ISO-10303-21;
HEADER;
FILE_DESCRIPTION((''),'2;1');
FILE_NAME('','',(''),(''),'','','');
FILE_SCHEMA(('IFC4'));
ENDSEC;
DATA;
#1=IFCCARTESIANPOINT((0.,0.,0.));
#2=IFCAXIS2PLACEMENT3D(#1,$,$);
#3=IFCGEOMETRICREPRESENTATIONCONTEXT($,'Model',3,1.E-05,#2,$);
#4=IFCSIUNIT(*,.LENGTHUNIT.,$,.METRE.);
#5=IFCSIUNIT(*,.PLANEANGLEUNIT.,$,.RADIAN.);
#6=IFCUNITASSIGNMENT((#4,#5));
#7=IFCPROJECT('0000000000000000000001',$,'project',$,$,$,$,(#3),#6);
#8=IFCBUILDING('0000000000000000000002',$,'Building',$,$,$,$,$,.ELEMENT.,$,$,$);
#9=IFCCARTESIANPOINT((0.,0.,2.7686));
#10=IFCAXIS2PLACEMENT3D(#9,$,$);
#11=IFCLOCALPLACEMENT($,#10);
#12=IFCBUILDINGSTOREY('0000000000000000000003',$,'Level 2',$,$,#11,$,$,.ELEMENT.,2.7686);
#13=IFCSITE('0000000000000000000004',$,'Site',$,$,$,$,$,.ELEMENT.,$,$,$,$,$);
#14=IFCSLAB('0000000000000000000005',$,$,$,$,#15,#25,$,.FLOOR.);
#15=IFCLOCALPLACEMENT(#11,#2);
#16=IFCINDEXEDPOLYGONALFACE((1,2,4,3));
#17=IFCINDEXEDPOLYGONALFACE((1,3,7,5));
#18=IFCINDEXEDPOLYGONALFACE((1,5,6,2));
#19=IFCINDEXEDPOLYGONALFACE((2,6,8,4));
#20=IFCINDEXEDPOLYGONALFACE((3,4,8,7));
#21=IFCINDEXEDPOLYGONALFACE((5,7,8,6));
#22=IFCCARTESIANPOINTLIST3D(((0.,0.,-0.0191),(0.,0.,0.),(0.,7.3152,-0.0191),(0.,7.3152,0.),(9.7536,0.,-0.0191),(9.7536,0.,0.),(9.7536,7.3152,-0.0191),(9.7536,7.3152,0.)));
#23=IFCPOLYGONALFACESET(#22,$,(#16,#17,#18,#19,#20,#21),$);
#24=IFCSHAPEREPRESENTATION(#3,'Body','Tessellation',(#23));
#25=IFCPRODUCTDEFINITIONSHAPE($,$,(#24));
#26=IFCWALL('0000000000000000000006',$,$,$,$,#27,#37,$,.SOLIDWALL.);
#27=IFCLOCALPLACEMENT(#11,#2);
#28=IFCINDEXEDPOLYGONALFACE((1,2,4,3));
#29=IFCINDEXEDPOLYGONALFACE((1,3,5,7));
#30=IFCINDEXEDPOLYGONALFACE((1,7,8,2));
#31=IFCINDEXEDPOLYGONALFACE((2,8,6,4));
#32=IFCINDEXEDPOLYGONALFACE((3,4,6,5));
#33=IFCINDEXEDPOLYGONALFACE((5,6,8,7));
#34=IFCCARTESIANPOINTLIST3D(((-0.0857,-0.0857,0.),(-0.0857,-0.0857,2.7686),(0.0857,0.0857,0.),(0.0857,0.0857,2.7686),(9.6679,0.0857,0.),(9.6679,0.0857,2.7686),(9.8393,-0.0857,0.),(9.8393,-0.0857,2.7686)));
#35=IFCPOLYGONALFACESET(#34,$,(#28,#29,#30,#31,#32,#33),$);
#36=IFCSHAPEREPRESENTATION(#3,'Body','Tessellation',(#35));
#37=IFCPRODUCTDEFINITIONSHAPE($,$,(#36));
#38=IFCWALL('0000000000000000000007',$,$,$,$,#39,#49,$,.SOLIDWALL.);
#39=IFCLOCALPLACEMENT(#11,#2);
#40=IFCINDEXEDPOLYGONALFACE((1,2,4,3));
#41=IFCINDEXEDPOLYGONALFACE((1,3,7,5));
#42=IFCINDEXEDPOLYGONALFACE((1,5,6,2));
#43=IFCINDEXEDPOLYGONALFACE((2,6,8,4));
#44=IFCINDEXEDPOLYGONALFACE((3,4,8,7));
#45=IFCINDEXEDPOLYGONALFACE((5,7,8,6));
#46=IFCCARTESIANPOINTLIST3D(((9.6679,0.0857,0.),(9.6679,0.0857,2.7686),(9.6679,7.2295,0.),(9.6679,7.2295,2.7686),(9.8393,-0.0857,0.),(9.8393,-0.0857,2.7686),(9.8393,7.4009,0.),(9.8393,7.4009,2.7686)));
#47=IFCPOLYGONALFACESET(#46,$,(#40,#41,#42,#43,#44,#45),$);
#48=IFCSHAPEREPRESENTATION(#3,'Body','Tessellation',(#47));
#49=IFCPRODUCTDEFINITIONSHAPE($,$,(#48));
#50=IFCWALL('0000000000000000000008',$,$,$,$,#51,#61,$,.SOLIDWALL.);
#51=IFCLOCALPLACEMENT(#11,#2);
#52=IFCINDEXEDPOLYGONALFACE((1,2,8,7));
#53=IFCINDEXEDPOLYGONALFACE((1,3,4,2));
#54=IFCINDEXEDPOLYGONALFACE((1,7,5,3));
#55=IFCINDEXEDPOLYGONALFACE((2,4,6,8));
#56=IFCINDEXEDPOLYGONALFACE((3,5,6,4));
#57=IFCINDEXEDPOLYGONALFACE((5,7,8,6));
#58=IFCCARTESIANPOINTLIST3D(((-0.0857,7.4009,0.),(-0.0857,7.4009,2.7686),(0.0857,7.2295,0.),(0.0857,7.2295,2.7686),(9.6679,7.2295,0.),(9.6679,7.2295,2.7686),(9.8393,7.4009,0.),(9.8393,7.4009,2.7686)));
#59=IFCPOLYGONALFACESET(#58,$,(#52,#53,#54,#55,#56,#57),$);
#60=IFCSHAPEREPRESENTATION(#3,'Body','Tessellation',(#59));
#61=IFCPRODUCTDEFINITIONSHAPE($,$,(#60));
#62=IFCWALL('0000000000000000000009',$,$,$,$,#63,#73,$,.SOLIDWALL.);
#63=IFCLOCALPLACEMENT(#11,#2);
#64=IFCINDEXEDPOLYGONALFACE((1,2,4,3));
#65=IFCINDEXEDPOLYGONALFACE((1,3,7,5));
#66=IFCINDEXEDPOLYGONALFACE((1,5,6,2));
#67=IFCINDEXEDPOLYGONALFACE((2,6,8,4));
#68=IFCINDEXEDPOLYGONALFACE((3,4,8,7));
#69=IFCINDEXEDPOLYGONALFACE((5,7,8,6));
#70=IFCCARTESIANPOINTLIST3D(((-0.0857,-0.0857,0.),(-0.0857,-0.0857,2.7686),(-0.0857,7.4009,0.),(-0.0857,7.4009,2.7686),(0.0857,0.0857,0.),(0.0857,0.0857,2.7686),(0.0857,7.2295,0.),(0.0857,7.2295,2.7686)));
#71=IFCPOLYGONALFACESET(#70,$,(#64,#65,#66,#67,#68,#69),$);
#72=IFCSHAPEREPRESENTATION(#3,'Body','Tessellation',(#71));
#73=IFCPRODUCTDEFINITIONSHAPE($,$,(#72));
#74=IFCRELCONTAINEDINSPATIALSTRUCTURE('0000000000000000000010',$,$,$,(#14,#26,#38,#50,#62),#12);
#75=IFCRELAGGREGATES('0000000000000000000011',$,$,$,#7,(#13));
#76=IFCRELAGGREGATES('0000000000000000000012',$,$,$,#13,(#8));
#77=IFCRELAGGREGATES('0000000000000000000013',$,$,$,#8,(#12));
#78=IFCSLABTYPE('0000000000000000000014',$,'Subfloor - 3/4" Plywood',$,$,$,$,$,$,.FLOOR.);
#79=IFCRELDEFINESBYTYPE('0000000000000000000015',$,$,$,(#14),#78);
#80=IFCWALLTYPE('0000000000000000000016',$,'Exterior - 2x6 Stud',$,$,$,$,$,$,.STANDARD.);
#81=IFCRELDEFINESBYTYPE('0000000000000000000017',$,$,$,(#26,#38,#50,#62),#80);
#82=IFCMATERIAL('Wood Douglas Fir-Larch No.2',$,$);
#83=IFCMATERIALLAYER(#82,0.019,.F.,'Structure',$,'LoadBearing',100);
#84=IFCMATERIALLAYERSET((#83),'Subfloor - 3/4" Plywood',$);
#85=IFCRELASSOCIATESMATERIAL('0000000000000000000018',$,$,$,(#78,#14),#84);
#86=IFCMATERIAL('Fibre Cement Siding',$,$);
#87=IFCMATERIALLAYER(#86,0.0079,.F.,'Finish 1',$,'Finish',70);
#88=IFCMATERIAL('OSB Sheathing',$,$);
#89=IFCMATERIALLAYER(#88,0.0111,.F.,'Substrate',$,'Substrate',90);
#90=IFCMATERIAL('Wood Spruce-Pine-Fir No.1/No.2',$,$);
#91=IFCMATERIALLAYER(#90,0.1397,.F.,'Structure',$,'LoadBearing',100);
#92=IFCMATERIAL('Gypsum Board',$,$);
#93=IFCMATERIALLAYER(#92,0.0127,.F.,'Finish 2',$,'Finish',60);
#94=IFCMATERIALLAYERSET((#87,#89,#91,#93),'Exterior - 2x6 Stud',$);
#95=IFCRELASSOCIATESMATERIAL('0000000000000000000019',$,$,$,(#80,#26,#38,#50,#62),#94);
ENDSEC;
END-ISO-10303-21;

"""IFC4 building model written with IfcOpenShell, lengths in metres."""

from ifc_helpers import new_model, si_unit, frame, origin, place, context, project, spatial, polyline, outline, extrude, material, layer, layer_set, layer_usage, type_object, element, save


model = new_model("IFC4")

# Units and contexts
model_context = context("Model", 3, precision=1e-05, world=origin())
ifc_project = project(units=[si_unit("LENGTHUNIT", "METRE"), si_unit("PLANEANGLEUNIT", "RADIAN")], contexts=[model_context])

# Site, building, storey
site = spatial("IfcSite", under=ifc_project, Name="Site", CompositionType="ELEMENT")
building = spatial("IfcBuilding", under=site, Name="Building", CompositionType="ELEMENT")
storey_placement = place(None, frame((0.0, 0.0, 2.7686)))
storey = spatial("IfcBuildingStorey", under=building, at=storey_placement, Name="Level 2", CompositionType="ELEMENT", Elevation=2.7686)

# Slab
ifc_material_1 = material(Name="Wood Douglas Fir-Larch No.2")
ifc_layer_1 = layer(ifc_material_1, 0.019, ventilated=False, Name="Structure", Category="LoadBearing", Priority=100)
ifc_layer_set_1 = layer_set([ifc_layer_1], Name="Subfloor - 3/4\" Plywood")
ifc_layer_usage_1 = layer_usage(ifc_layer_set_1, "AXIS3", "NEGATIVE", 0.0)
slab_type = type_object("IfcSlabType", Name="Subfloor - 3/4\" Plywood", PredefinedType="FLOOR", material=ifc_layer_set_1)
slab_placement = place(None, frame((0.0, 0.0, 2.7686)))
element("IfcSlab", 1, at=slab_placement, inside=storey, type_object=slab_type, material=ifc_layer_usage_1, PredefinedType="FLOOR", context=model_context, shape_type="SweptSolid", body=[
    extrude(outline(polyline([(0.0, 0.0), (9.7536, 0.0), (9.7536, 7.3152), (0.0, 7.3152), (0.0, 0.0)])), origin(), (0.0, 0.0, -1.0), 0.019),
])

# Walls
ifc_material_2 = material(Name="Fibre Cement Siding")
ifc_layer_2 = layer(ifc_material_2, 0.0079, ventilated=False, Name="Finish 1", Category="Finish", Priority=70)
ifc_material_3 = material(Name="OSB Sheathing")
ifc_layer_3 = layer(ifc_material_3, 0.0111, ventilated=False, Name="Substrate", Category="Substrate", Priority=90)
ifc_material_4 = material(Name="Wood Spruce-Pine-Fir No.1/No.2")
ifc_layer_4 = layer(ifc_material_4, 0.1397, ventilated=False, Name="Structure", Category="LoadBearing", Priority=100)
ifc_material_5 = material(Name="Gypsum Board")
ifc_layer_5 = layer(ifc_material_5, 0.0127, ventilated=False, Name="Finish 2", Category="Finish", Priority=60)
ifc_layer_set_2 = layer_set([ifc_layer_2, ifc_layer_3, ifc_layer_4, ifc_layer_5], Name="Exterior - 2x6 Stud")
ifc_layer_usage_2 = layer_usage(ifc_layer_set_2, "AXIS2", "POSITIVE", -0.0857)
wall_type = type_object("IfcWallType", Name="Exterior - 2x6 Stud", PredefinedType="STANDARD", material=ifc_layer_set_2)
wall_1_placement = place(None, frame((9.7536, 0.0, 2.7686), z_axis=(0.0, 0.0, 1.0), x_axis=(-1.0, 0.0, 0.0)))
element("IfcWall", 2, at=wall_1_placement, inside=storey, type_object=wall_type, material=ifc_layer_usage_2, PredefinedType="SOLIDWALL", context=model_context, shape_type="SweptSolid", body=[
    extrude(outline(polyline([(0.0857, -0.0857), (9.6679, -0.0857), (9.8393, 0.0857), (-0.0857, 0.0857), (0.0857, -0.0857)])), origin(), (0.0, 0.0, 1.0), 2.7686),
])
wall_2_placement = place(None, frame((9.7536, 7.3152, 2.7686), z_axis=(0.0, 0.0, 1.0), x_axis=(0.0, -1.0, 0.0)))
element("IfcWall", 3, at=wall_2_placement, inside=storey, type_object=wall_type, material=ifc_layer_usage_2, PredefinedType="SOLIDWALL", context=model_context, shape_type="SweptSolid", body=[
    extrude(outline(polyline([(0.0857, -0.0857), (7.2295, -0.0857), (7.4009, 0.0857), (-0.0857, 0.0857), (0.0857, -0.0857)])), origin(), (0.0, 0.0, 1.0), 2.7686),
])
wall_3_placement = place(None, frame((0.0, 7.3152, 2.7686), z_axis=(0.0, 0.0, 1.0), x_axis=(1.0, 0.0, 0.0)))
element("IfcWall", 4, at=wall_3_placement, inside=storey, type_object=wall_type, material=ifc_layer_usage_2, PredefinedType="SOLIDWALL", context=model_context, shape_type="SweptSolid", body=[
    extrude(outline(polyline([(0.0857, -0.0857), (9.6679, -0.0857), (9.8393, 0.0857), (-0.0857, 0.0857), (0.0857, -0.0857)])), origin(), (0.0, 0.0, 1.0), 2.7686),
])
wall_4_placement = place(None, frame((0.0, 0.0, 2.7686), z_axis=(0.0, 0.0, 1.0), x_axis=(0.0, 1.0, 0.0)))
element("IfcWall", 5, at=wall_4_placement, inside=storey, type_object=wall_type, material=ifc_layer_usage_2, PredefinedType="SOLIDWALL", context=model_context, shape_type="SweptSolid", body=[
    extrude(outline(polyline([(0.0857, -0.0857), (7.2295, -0.0857), (7.4009, 0.0857), (-0.0857, 0.0857), (0.0857, -0.0857)])), origin(), (0.0, 0.0, 1.0), 2.7686),
])

save(model, "model.ifc")
